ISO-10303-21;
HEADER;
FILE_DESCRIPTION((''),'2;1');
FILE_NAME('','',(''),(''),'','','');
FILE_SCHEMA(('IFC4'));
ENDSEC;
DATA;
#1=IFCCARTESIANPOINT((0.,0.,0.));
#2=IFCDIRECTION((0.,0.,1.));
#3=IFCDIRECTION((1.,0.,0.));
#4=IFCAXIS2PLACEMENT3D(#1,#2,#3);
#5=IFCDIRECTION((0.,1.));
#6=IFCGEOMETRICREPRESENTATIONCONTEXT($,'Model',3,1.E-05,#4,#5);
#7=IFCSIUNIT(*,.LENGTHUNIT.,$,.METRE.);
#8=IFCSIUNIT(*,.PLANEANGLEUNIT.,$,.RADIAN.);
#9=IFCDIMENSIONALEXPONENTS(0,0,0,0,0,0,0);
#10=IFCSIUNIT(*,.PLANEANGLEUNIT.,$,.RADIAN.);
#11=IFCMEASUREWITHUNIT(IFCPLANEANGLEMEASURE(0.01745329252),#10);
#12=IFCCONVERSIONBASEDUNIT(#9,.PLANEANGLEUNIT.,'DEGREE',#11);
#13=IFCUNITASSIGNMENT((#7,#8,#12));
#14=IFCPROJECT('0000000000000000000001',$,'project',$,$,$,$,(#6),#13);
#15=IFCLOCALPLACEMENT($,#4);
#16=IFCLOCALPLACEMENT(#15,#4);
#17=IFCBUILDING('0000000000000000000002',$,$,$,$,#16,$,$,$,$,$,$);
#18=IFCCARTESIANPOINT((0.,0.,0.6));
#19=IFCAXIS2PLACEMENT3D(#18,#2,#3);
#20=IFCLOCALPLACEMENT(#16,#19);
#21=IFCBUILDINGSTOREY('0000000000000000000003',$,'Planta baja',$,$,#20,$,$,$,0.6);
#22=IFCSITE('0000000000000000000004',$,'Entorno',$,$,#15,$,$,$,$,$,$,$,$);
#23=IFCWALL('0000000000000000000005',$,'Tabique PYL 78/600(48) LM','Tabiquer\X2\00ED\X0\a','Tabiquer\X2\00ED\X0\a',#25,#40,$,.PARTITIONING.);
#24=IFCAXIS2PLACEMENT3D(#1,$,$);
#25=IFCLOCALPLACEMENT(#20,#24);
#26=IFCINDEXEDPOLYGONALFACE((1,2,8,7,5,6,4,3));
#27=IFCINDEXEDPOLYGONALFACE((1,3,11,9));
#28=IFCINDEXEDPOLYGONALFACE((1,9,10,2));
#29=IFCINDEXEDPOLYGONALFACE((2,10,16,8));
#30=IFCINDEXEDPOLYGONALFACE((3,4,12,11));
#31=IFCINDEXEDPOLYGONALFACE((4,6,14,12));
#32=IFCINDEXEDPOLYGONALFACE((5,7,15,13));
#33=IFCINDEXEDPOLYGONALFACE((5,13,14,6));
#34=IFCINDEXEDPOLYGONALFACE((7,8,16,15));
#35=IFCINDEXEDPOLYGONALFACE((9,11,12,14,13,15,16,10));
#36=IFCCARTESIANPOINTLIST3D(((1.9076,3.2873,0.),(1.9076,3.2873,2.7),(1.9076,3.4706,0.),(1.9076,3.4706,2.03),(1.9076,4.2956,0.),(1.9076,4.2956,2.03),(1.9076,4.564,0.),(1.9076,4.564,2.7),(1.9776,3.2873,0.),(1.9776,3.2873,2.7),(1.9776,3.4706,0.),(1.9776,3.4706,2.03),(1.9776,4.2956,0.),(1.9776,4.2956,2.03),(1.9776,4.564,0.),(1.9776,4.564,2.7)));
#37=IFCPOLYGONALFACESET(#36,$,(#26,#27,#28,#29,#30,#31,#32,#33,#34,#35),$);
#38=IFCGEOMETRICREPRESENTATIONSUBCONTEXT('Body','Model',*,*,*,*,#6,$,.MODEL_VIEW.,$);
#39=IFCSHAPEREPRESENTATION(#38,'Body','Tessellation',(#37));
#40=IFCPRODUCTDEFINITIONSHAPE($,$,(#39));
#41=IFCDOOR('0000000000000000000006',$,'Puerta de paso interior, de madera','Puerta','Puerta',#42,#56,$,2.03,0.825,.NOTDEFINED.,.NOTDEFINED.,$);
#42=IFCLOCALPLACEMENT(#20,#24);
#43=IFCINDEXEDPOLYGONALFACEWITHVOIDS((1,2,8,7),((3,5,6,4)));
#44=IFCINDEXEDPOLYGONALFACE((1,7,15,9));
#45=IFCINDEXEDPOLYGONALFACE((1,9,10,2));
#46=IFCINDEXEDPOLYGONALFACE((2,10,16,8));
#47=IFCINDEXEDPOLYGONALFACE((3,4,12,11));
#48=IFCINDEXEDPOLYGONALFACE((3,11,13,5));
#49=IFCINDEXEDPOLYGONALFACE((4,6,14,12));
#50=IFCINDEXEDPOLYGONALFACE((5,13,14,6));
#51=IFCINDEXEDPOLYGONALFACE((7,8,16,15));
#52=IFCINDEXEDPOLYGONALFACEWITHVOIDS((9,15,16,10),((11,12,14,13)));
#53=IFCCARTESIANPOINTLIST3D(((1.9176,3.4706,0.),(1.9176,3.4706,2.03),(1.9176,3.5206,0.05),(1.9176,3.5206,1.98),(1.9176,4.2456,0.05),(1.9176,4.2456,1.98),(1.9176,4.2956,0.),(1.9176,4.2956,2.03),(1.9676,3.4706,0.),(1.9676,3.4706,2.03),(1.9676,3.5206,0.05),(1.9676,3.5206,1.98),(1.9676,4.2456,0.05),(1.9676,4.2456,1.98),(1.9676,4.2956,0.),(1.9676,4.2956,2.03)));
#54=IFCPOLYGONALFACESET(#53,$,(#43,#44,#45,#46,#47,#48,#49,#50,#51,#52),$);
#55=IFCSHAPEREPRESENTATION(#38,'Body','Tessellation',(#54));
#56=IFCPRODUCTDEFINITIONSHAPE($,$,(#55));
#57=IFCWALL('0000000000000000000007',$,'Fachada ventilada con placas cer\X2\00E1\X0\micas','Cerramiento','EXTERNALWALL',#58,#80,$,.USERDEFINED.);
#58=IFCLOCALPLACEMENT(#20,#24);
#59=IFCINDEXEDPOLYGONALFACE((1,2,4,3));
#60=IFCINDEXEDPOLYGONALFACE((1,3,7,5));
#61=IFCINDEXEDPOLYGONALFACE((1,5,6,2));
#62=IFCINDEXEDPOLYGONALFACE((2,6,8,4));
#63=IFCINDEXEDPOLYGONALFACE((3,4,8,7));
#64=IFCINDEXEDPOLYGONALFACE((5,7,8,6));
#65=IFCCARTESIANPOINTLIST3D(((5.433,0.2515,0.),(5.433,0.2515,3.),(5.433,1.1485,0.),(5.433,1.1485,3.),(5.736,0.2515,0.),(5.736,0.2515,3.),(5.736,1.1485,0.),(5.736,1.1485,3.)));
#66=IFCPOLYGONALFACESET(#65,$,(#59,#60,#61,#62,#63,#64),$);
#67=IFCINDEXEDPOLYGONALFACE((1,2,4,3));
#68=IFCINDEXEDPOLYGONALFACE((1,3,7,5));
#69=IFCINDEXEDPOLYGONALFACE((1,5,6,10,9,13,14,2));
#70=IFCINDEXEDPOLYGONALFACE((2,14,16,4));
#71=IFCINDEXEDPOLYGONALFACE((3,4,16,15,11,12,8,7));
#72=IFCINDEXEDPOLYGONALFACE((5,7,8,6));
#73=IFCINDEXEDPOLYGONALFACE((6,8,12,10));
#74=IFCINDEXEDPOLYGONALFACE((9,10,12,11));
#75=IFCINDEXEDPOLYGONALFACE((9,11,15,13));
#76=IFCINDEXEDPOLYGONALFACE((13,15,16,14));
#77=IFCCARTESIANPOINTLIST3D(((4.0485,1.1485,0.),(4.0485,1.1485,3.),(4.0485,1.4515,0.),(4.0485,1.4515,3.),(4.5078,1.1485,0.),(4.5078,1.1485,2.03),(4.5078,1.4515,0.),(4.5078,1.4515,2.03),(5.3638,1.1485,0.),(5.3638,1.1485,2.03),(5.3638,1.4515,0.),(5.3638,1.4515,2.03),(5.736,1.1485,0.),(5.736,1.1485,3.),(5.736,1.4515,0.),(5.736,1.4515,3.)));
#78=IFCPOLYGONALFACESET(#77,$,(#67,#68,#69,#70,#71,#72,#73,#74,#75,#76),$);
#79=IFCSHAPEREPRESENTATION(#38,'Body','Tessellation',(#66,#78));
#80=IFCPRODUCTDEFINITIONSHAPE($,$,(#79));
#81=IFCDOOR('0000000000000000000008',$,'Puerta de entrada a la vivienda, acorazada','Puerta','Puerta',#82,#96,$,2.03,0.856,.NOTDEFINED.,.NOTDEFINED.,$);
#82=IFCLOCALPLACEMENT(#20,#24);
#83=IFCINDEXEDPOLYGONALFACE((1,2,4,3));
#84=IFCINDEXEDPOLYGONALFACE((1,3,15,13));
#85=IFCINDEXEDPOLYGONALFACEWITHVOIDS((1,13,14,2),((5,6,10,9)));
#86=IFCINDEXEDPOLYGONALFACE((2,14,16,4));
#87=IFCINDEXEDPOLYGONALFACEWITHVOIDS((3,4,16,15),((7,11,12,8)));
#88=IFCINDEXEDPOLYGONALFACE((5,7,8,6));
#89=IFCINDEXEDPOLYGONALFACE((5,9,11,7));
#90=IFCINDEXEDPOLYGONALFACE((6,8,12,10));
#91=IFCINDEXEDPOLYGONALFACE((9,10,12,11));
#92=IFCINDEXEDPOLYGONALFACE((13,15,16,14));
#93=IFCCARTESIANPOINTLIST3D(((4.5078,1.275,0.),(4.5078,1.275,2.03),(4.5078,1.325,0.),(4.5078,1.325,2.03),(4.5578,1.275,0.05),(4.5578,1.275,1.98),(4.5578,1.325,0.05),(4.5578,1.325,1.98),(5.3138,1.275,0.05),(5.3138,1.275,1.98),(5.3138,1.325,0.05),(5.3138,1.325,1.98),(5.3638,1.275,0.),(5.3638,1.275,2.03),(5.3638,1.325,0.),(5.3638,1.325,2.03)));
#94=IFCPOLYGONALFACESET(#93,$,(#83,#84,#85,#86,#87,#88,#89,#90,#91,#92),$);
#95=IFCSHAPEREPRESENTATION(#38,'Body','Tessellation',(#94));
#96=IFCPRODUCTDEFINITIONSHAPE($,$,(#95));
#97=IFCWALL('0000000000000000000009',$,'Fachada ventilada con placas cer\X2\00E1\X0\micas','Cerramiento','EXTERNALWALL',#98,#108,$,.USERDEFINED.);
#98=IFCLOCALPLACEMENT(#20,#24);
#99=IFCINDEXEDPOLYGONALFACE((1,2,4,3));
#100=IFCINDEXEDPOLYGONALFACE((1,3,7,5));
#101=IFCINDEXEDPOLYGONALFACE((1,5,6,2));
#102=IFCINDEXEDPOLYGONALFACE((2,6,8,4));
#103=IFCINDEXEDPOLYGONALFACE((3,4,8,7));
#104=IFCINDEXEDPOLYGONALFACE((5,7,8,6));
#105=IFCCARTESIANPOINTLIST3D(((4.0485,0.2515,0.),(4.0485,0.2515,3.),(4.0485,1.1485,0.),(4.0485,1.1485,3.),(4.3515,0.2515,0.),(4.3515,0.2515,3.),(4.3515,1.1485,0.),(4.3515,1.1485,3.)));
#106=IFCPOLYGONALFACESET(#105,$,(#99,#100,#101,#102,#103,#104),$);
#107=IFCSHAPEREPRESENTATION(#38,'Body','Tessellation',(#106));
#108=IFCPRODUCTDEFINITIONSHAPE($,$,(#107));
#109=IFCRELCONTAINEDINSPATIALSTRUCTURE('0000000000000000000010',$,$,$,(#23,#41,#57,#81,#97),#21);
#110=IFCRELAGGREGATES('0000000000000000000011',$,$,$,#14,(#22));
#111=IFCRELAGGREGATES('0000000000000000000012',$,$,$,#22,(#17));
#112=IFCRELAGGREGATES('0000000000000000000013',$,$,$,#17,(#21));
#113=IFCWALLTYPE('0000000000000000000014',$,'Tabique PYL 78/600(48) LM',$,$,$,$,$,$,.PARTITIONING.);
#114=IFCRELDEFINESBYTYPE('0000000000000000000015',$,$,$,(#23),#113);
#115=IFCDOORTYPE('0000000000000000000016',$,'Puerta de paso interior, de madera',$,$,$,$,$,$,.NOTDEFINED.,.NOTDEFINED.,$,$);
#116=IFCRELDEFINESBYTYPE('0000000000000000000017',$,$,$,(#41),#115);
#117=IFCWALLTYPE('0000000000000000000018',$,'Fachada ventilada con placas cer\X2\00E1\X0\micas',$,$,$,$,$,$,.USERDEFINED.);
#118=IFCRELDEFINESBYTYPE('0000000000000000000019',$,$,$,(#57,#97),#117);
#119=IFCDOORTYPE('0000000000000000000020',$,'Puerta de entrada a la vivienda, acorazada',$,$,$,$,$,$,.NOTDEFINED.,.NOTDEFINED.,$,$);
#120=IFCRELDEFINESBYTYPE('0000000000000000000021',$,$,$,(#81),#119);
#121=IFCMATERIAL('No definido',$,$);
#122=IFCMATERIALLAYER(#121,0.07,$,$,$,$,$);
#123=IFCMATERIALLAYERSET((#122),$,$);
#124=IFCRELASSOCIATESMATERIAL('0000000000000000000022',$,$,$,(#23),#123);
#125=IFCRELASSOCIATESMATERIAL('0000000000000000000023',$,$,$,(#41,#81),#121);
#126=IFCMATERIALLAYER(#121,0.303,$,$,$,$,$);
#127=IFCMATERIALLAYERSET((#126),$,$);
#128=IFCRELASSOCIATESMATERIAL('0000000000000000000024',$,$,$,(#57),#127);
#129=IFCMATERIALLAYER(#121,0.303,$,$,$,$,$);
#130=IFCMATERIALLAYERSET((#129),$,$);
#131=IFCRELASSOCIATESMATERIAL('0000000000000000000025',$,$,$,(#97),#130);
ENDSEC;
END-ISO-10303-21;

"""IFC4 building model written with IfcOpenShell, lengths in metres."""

from ifc_helpers import new_model, entity, si_unit, converted_unit, direction, frame, origin_with_axes, origin_2d_with_axis, place, context, subcontext, project, spatial, rectangle, hollow_rectangle, extrude, shape, material, layer, layer_set, layer_usage, type_object, element, fill, save


model = new_model("IFC4")

# Units and contexts
model_context = context("Model", 3, precision=1e-05, world=origin_with_axes(), true_north=direction((0.0, 1.0)))
body_context = subcontext(model_context, "Body", "Model", "MODEL_VIEW")
footprint_context = subcontext(model_context, "FootPrint", "Model", "MODEL_VIEW")
ifc_project = project(units=[si_unit("LENGTHUNIT", "METRE"), si_unit("PLANEANGLEUNIT", "RADIAN"), converted_unit("PLANEANGLEUNIT", "DEGREE", entity("IfcPlaneAngleMeasure", 0.01745329252), si_unit("PLANEANGLEUNIT", "RADIAN"), dimensions=[0, 0, 0, 0, 0, 0, 0])], contexts=[model_context])

# Site, building, storey
site_placement = place(None, origin_with_axes())
site = spatial("IfcSite", under=ifc_project, at=site_placement, Name="Entorno")
building_placement = place(site_placement, origin_with_axes())
building = spatial("IfcBuilding", under=site, at=building_placement)
storey_placement = place(building_placement, frame((0.0, 0.0, 0.6), z_axis=(0.0, 0.0, 1.0), x_axis=(1.0, 0.0, 0.0)))
storey = spatial("IfcBuildingStorey", under=building, at=storey_placement, Name="Planta baja", Elevation=0.6)

# Shared definitions
ifc_material = material(Name="No definido")

# Shared definitions
wall_type_1 = type_object("IfcWallType", Name="Tabique PYL 78/600(48) LM", PredefinedType="PARTITIONING")

# Walls, openings, doors
door_type_1 = type_object("IfcDoorType", Name="Puerta de paso interior, de madera", OperationType="NOTDEFINED", PredefinedType="NOTDEFINED")
ifc_layer_1 = layer(ifc_material, 0.07)
ifc_layer_set_1 = layer_set([ifc_layer_1])
ifc_layer_usage_1 = layer_usage(ifc_layer_set_1, "AXIS2", "POSITIVE", -0.035)
wall_1_placement = place(storey_placement, frame((1.9426, 3.25, 0.0), z_axis=(0.0, 0.0, 1.0), x_axis=(0.0, 1.0, 0.0)))
cartesian_point_1 = entity("IfcCartesianPoint", [-0.6383, -1.35])
cartesian_point_2 = entity("IfcCartesianPoint", [-0.6383, -1.35])
wall_1 = element("IfcWall", 1, at=wall_1_placement, inside=storey, type_object=wall_type_1, material=ifc_layer_usage_1, Name="Tabique PYL 78/600(48) LM", Description="Tabiquería", ObjectType="Tabiquería", PredefinedType="PARTITIONING", context=body_context, shape_type="SolidModel", body=[
    entity("IfcExtrudedAreaSolidTapered", entity("IfcArbitraryClosedProfileDef", "AREA", None, entity("IfcPolyline", [cartesian_point_1, entity("IfcCartesianPoint", [0.6383, -1.35]), entity("IfcCartesianPoint", [0.6383, 1.35]), entity("IfcCartesianPoint", [-0.6383, 1.35]), cartesian_point_1])), entity("IfcAxis2Placement3D", entity("IfcCartesianPoint", [0.6757, 0.035, 1.35]), entity("IfcDirection", [0.0, -1.0, 0.0]), entity("IfcDirection", [1.0, 0.0, 0.0])), entity("IfcDirection", [0.0, 0.0, 1.0]), 0.07, entity("IfcArbitraryClosedProfileDef", "AREA", None, entity("IfcPolyline", [cartesian_point_2, entity("IfcCartesianPoint", [0.6383, -1.35]), entity("IfcCartesianPoint", [0.6383, 1.35]), entity("IfcCartesianPoint", [-0.6383, 1.35]), cartesian_point_2]))),
])
opening_1_placement = place(wall_1_placement, frame((0.6331, 0.0, 1.015), z_axis=(0.0, 0.0, 1.0), x_axis=(1.0, 0.0, 0.0)))
cartesian_point_3 = entity("IfcCartesianPoint", [-0.4125, -0.035])
opening_1 = element("IfcOpeningElement", 2, at=opening_1_placement, cuts=wall_1, ObjectType="No definido", PredefinedType="OPENING", shapes=[
    shape(body_context, "Body", "SweptSolid", [extrude(rectangle(XDim=2.03, YDim=0.825, at=origin_2d_with_axis()), frame((0.0, -0.035, 0.0), z_axis=(0.0, 1.0, 0.0), x_axis=(0.0, 0.0, 1.0)), (0.0, 0.0, 1.0), 0.07)]),
    shape(footprint_context, "FootPrint", "GeometricCurveSet", [entity("IfcGeometricCurveSet", [entity("IfcPolyline", [cartesian_point_3, entity("IfcCartesianPoint", [0.4125, -0.035]), entity("IfcCartesianPoint", [0.4125, 0.035]), entity("IfcCartesianPoint", [-0.4125, 0.035]), cartesian_point_3])])]),
])
door_1_placement = place(opening_1_placement, origin_with_axes())
door_1 = element("IfcDoor", 3, at=door_1_placement, inside=storey, type_object=door_type_1, material=ifc_material, Name="Puerta de paso interior, de madera", Description="Puerta", ObjectType="Puerta", OperationType="NOTDEFINED", OverallHeight=2.03, OverallWidth=0.825, PredefinedType="NOTDEFINED", context=body_context, shape_type="SweptSolid", body=[
    extrude(hollow_rectangle(XDim=0.825, YDim=2.03, WallThickness=0.05, InnerFilletRadius=0.0, OuterFilletRadius=0.0, at=origin_2d_with_axis()), frame((0.0, 0.025, 0.0), z_axis=(0.0, -1.0, 0.0), x_axis=(1.0, 0.0, 0.0)), (0.0, 0.0, 1.0), 0.05),
])
fill(opening_1, door_1)
ifc_layer_2 = layer(ifc_material, 0.303)
ifc_layer_set_2 = layer_set([ifc_layer_2])
ifc_layer_usage_2 = layer_usage(ifc_layer_set_2, "AXIS2", "POSITIVE", -0.1515)
wall_type_2 = type_object("IfcWallType", Name="Fachada ventilada con placas cerámicas", PredefinedType="USERDEFINED")
wall_2_placement = place(storey_placement, frame((5.5845, 0.1, 0.0), z_axis=(0.0, 0.0, 1.0), x_axis=(0.0, 1.0, 0.0)))
cartesian_point_4 = entity("IfcCartesianPoint", [-0.4485, -1.5])
cartesian_point_5 = entity("IfcCartesianPoint", [-0.4485, -1.5])
cartesian_point_6 = entity("IfcCartesianPoint", [-0.8438, -1.5])
cartesian_point_7 = entity("IfcCartesianPoint", [-0.8438, -1.5])
wall_2 = element("IfcWall", 4, at=wall_2_placement, inside=storey, type_object=wall_type_2, material=ifc_layer_usage_2, Name="Fachada ventilada con placas cerámicas", Description="Cerramiento", ObjectType="EXTERNALWALL", PredefinedType="USERDEFINED", context=body_context, shape_type="SolidModel", body=[
    entity("IfcExtrudedAreaSolidTapered", entity("IfcArbitraryClosedProfileDef", "AREA", None, entity("IfcPolyline", [cartesian_point_4, entity("IfcCartesianPoint", [0.4485, -1.5]), entity("IfcCartesianPoint", [0.4485, 1.5]), entity("IfcCartesianPoint", [-0.4485, 1.5]), cartesian_point_4])), entity("IfcAxis2Placement3D", entity("IfcCartesianPoint", [0.6, 0.1515, 1.5]), entity("IfcDirection", [0.0, -1.0, 0.0]), entity("IfcDirection", [1.0, 0.0, 0.0])), entity("IfcDirection", [0.0, 0.0, 1.0]), 0.303, entity("IfcArbitraryClosedProfileDef", "AREA", None, entity("IfcPolyline", [cartesian_point_5, entity("IfcCartesianPoint", [0.4485, -1.5]), entity("IfcCartesianPoint", [0.4485, 1.5]), entity("IfcCartesianPoint", [-0.4485, 1.5]), cartesian_point_5]))),
    entity("IfcExtrudedAreaSolidTapered", entity("IfcArbitraryClosedProfileDef", "AREA", None, entity("IfcPolyline", [cartesian_point_6, entity("IfcCartesianPoint", [0.8438, -1.5]), entity("IfcCartesianPoint", [0.8438, 1.5]), entity("IfcCartesianPoint", [-0.8438, 1.5]), cartesian_point_6])), entity("IfcAxis2Placement3D", entity("IfcCartesianPoint", [1.0485, 0.6923, 1.5]), entity("IfcDirection", [1.0, 0.0, 0.0]), entity("IfcDirection", [0.0, 1.0, 0.0])), entity("IfcDirection", [0.0, 0.0, 1.0]), 0.303, entity("IfcArbitraryClosedProfileDef", "AREA", None, entity("IfcPolyline", [cartesian_point_7, entity("IfcCartesianPoint", [0.8438, -1.5]), entity("IfcCartesianPoint", [0.8438, 1.5]), entity("IfcCartesianPoint", [-0.8438, 1.5]), cartesian_point_7]))),
])
opening_2_placement = place(wall_2_placement, frame((1.2, 0.6487, 1.015), z_axis=(0.0, 0.0, 1.0), x_axis=(0.0, 1.0, 0.0)))
cartesian_point_8 = entity("IfcCartesianPoint", [-0.428, -0.1515])
opening_2 = element("IfcOpeningElement", 5, at=opening_2_placement, cuts=wall_2, ObjectType="No definido", PredefinedType="OPENING", shapes=[
    shape(body_context, "Body", "SweptSolid", [extrude(rectangle(XDim=2.03, YDim=0.856, at=origin_2d_with_axis()), frame((0.0, -0.1515, 0.0), z_axis=(0.0, 1.0, 0.0), x_axis=(0.0, 0.0, 1.0)), (0.0, 0.0, 1.0), 0.303)]),
    shape(footprint_context, "FootPrint", "GeometricCurveSet", [entity("IfcGeometricCurveSet", [entity("IfcPolyline", [cartesian_point_8, entity("IfcCartesianPoint", [0.428, -0.1515]), entity("IfcCartesianPoint", [0.428, 0.1515]), entity("IfcCartesianPoint", [-0.428, 0.1515]), cartesian_point_8])])]),
])
door_type_2 = type_object("IfcDoorType", Name="Puerta de entrada a la vivienda, acorazada", OperationType="NOTDEFINED", PredefinedType="NOTDEFINED")
door_2_placement = place(opening_2_placement, origin_with_axes())
door_2 = element("IfcDoor", 6, at=door_2_placement, inside=storey, type_object=door_type_2, material=ifc_material, Name="Puerta de entrada a la vivienda, acorazada", Description="Puerta", ObjectType="Puerta", OperationType="NOTDEFINED", OverallHeight=2.03, OverallWidth=0.856, PredefinedType="NOTDEFINED", context=body_context, shape_type="SweptSolid", body=[
    extrude(hollow_rectangle(XDim=0.856, YDim=2.03, WallThickness=0.05, InnerFilletRadius=0.0, OuterFilletRadius=0.0, at=origin_2d_with_axis()), frame((0.0, 0.025, 0.0), z_axis=(0.0, -1.0, 0.0), x_axis=(1.0, 0.0, 0.0)), (0.0, 0.0, 1.0), 0.05),
])
fill(opening_2, door_2)

# Wall
ifc_layer_3 = layer(ifc_material, 0.303)
ifc_layer_set_3 = layer_set([ifc_layer_3])
ifc_layer_usage_3 = layer_usage(ifc_layer_set_3, "AXIS2", "POSITIVE", -0.1515)
wall_3_placement = place(storey_placement, frame((4.2, 1.3, 0.0), z_axis=(0.0, 0.0, 1.0), x_axis=(0.0, -1.0, 0.0)))
cartesian_point_9 = entity("IfcCartesianPoint", [-0.4485, -1.5])
cartesian_point_10 = entity("IfcCartesianPoint", [-0.4485, -1.5])
element("IfcWall", 7, at=wall_3_placement, inside=storey, type_object=wall_type_2, material=ifc_layer_usage_3, Name="Fachada ventilada con placas cerámicas", Description="Cerramiento", ObjectType="EXTERNALWALL", PredefinedType="USERDEFINED", context=body_context, shape_type="SolidModel", body=[
    entity("IfcExtrudedAreaSolidTapered", entity("IfcArbitraryClosedProfileDef", "AREA", None, entity("IfcPolyline", [cartesian_point_9, entity("IfcCartesianPoint", [0.4485, -1.5]), entity("IfcCartesianPoint", [0.4485, 1.5]), entity("IfcCartesianPoint", [-0.4485, 1.5]), cartesian_point_9])), entity("IfcAxis2Placement3D", entity("IfcCartesianPoint", [0.6, 0.1515, 1.5]), entity("IfcDirection", [0.0, -1.0, 0.0]), entity("IfcDirection", [1.0, 0.0, 0.0])), entity("IfcDirection", [0.0, 0.0, 1.0]), 0.303, entity("IfcArbitraryClosedProfileDef", "AREA", None, entity("IfcPolyline", [cartesian_point_10, entity("IfcCartesianPoint", [0.4485, -1.5]), entity("IfcCartesianPoint", [0.4485, 1.5]), entity("IfcCartesianPoint", [-0.4485, 1.5]), cartesian_point_10]))),
])

save(model, "model.ifc")
